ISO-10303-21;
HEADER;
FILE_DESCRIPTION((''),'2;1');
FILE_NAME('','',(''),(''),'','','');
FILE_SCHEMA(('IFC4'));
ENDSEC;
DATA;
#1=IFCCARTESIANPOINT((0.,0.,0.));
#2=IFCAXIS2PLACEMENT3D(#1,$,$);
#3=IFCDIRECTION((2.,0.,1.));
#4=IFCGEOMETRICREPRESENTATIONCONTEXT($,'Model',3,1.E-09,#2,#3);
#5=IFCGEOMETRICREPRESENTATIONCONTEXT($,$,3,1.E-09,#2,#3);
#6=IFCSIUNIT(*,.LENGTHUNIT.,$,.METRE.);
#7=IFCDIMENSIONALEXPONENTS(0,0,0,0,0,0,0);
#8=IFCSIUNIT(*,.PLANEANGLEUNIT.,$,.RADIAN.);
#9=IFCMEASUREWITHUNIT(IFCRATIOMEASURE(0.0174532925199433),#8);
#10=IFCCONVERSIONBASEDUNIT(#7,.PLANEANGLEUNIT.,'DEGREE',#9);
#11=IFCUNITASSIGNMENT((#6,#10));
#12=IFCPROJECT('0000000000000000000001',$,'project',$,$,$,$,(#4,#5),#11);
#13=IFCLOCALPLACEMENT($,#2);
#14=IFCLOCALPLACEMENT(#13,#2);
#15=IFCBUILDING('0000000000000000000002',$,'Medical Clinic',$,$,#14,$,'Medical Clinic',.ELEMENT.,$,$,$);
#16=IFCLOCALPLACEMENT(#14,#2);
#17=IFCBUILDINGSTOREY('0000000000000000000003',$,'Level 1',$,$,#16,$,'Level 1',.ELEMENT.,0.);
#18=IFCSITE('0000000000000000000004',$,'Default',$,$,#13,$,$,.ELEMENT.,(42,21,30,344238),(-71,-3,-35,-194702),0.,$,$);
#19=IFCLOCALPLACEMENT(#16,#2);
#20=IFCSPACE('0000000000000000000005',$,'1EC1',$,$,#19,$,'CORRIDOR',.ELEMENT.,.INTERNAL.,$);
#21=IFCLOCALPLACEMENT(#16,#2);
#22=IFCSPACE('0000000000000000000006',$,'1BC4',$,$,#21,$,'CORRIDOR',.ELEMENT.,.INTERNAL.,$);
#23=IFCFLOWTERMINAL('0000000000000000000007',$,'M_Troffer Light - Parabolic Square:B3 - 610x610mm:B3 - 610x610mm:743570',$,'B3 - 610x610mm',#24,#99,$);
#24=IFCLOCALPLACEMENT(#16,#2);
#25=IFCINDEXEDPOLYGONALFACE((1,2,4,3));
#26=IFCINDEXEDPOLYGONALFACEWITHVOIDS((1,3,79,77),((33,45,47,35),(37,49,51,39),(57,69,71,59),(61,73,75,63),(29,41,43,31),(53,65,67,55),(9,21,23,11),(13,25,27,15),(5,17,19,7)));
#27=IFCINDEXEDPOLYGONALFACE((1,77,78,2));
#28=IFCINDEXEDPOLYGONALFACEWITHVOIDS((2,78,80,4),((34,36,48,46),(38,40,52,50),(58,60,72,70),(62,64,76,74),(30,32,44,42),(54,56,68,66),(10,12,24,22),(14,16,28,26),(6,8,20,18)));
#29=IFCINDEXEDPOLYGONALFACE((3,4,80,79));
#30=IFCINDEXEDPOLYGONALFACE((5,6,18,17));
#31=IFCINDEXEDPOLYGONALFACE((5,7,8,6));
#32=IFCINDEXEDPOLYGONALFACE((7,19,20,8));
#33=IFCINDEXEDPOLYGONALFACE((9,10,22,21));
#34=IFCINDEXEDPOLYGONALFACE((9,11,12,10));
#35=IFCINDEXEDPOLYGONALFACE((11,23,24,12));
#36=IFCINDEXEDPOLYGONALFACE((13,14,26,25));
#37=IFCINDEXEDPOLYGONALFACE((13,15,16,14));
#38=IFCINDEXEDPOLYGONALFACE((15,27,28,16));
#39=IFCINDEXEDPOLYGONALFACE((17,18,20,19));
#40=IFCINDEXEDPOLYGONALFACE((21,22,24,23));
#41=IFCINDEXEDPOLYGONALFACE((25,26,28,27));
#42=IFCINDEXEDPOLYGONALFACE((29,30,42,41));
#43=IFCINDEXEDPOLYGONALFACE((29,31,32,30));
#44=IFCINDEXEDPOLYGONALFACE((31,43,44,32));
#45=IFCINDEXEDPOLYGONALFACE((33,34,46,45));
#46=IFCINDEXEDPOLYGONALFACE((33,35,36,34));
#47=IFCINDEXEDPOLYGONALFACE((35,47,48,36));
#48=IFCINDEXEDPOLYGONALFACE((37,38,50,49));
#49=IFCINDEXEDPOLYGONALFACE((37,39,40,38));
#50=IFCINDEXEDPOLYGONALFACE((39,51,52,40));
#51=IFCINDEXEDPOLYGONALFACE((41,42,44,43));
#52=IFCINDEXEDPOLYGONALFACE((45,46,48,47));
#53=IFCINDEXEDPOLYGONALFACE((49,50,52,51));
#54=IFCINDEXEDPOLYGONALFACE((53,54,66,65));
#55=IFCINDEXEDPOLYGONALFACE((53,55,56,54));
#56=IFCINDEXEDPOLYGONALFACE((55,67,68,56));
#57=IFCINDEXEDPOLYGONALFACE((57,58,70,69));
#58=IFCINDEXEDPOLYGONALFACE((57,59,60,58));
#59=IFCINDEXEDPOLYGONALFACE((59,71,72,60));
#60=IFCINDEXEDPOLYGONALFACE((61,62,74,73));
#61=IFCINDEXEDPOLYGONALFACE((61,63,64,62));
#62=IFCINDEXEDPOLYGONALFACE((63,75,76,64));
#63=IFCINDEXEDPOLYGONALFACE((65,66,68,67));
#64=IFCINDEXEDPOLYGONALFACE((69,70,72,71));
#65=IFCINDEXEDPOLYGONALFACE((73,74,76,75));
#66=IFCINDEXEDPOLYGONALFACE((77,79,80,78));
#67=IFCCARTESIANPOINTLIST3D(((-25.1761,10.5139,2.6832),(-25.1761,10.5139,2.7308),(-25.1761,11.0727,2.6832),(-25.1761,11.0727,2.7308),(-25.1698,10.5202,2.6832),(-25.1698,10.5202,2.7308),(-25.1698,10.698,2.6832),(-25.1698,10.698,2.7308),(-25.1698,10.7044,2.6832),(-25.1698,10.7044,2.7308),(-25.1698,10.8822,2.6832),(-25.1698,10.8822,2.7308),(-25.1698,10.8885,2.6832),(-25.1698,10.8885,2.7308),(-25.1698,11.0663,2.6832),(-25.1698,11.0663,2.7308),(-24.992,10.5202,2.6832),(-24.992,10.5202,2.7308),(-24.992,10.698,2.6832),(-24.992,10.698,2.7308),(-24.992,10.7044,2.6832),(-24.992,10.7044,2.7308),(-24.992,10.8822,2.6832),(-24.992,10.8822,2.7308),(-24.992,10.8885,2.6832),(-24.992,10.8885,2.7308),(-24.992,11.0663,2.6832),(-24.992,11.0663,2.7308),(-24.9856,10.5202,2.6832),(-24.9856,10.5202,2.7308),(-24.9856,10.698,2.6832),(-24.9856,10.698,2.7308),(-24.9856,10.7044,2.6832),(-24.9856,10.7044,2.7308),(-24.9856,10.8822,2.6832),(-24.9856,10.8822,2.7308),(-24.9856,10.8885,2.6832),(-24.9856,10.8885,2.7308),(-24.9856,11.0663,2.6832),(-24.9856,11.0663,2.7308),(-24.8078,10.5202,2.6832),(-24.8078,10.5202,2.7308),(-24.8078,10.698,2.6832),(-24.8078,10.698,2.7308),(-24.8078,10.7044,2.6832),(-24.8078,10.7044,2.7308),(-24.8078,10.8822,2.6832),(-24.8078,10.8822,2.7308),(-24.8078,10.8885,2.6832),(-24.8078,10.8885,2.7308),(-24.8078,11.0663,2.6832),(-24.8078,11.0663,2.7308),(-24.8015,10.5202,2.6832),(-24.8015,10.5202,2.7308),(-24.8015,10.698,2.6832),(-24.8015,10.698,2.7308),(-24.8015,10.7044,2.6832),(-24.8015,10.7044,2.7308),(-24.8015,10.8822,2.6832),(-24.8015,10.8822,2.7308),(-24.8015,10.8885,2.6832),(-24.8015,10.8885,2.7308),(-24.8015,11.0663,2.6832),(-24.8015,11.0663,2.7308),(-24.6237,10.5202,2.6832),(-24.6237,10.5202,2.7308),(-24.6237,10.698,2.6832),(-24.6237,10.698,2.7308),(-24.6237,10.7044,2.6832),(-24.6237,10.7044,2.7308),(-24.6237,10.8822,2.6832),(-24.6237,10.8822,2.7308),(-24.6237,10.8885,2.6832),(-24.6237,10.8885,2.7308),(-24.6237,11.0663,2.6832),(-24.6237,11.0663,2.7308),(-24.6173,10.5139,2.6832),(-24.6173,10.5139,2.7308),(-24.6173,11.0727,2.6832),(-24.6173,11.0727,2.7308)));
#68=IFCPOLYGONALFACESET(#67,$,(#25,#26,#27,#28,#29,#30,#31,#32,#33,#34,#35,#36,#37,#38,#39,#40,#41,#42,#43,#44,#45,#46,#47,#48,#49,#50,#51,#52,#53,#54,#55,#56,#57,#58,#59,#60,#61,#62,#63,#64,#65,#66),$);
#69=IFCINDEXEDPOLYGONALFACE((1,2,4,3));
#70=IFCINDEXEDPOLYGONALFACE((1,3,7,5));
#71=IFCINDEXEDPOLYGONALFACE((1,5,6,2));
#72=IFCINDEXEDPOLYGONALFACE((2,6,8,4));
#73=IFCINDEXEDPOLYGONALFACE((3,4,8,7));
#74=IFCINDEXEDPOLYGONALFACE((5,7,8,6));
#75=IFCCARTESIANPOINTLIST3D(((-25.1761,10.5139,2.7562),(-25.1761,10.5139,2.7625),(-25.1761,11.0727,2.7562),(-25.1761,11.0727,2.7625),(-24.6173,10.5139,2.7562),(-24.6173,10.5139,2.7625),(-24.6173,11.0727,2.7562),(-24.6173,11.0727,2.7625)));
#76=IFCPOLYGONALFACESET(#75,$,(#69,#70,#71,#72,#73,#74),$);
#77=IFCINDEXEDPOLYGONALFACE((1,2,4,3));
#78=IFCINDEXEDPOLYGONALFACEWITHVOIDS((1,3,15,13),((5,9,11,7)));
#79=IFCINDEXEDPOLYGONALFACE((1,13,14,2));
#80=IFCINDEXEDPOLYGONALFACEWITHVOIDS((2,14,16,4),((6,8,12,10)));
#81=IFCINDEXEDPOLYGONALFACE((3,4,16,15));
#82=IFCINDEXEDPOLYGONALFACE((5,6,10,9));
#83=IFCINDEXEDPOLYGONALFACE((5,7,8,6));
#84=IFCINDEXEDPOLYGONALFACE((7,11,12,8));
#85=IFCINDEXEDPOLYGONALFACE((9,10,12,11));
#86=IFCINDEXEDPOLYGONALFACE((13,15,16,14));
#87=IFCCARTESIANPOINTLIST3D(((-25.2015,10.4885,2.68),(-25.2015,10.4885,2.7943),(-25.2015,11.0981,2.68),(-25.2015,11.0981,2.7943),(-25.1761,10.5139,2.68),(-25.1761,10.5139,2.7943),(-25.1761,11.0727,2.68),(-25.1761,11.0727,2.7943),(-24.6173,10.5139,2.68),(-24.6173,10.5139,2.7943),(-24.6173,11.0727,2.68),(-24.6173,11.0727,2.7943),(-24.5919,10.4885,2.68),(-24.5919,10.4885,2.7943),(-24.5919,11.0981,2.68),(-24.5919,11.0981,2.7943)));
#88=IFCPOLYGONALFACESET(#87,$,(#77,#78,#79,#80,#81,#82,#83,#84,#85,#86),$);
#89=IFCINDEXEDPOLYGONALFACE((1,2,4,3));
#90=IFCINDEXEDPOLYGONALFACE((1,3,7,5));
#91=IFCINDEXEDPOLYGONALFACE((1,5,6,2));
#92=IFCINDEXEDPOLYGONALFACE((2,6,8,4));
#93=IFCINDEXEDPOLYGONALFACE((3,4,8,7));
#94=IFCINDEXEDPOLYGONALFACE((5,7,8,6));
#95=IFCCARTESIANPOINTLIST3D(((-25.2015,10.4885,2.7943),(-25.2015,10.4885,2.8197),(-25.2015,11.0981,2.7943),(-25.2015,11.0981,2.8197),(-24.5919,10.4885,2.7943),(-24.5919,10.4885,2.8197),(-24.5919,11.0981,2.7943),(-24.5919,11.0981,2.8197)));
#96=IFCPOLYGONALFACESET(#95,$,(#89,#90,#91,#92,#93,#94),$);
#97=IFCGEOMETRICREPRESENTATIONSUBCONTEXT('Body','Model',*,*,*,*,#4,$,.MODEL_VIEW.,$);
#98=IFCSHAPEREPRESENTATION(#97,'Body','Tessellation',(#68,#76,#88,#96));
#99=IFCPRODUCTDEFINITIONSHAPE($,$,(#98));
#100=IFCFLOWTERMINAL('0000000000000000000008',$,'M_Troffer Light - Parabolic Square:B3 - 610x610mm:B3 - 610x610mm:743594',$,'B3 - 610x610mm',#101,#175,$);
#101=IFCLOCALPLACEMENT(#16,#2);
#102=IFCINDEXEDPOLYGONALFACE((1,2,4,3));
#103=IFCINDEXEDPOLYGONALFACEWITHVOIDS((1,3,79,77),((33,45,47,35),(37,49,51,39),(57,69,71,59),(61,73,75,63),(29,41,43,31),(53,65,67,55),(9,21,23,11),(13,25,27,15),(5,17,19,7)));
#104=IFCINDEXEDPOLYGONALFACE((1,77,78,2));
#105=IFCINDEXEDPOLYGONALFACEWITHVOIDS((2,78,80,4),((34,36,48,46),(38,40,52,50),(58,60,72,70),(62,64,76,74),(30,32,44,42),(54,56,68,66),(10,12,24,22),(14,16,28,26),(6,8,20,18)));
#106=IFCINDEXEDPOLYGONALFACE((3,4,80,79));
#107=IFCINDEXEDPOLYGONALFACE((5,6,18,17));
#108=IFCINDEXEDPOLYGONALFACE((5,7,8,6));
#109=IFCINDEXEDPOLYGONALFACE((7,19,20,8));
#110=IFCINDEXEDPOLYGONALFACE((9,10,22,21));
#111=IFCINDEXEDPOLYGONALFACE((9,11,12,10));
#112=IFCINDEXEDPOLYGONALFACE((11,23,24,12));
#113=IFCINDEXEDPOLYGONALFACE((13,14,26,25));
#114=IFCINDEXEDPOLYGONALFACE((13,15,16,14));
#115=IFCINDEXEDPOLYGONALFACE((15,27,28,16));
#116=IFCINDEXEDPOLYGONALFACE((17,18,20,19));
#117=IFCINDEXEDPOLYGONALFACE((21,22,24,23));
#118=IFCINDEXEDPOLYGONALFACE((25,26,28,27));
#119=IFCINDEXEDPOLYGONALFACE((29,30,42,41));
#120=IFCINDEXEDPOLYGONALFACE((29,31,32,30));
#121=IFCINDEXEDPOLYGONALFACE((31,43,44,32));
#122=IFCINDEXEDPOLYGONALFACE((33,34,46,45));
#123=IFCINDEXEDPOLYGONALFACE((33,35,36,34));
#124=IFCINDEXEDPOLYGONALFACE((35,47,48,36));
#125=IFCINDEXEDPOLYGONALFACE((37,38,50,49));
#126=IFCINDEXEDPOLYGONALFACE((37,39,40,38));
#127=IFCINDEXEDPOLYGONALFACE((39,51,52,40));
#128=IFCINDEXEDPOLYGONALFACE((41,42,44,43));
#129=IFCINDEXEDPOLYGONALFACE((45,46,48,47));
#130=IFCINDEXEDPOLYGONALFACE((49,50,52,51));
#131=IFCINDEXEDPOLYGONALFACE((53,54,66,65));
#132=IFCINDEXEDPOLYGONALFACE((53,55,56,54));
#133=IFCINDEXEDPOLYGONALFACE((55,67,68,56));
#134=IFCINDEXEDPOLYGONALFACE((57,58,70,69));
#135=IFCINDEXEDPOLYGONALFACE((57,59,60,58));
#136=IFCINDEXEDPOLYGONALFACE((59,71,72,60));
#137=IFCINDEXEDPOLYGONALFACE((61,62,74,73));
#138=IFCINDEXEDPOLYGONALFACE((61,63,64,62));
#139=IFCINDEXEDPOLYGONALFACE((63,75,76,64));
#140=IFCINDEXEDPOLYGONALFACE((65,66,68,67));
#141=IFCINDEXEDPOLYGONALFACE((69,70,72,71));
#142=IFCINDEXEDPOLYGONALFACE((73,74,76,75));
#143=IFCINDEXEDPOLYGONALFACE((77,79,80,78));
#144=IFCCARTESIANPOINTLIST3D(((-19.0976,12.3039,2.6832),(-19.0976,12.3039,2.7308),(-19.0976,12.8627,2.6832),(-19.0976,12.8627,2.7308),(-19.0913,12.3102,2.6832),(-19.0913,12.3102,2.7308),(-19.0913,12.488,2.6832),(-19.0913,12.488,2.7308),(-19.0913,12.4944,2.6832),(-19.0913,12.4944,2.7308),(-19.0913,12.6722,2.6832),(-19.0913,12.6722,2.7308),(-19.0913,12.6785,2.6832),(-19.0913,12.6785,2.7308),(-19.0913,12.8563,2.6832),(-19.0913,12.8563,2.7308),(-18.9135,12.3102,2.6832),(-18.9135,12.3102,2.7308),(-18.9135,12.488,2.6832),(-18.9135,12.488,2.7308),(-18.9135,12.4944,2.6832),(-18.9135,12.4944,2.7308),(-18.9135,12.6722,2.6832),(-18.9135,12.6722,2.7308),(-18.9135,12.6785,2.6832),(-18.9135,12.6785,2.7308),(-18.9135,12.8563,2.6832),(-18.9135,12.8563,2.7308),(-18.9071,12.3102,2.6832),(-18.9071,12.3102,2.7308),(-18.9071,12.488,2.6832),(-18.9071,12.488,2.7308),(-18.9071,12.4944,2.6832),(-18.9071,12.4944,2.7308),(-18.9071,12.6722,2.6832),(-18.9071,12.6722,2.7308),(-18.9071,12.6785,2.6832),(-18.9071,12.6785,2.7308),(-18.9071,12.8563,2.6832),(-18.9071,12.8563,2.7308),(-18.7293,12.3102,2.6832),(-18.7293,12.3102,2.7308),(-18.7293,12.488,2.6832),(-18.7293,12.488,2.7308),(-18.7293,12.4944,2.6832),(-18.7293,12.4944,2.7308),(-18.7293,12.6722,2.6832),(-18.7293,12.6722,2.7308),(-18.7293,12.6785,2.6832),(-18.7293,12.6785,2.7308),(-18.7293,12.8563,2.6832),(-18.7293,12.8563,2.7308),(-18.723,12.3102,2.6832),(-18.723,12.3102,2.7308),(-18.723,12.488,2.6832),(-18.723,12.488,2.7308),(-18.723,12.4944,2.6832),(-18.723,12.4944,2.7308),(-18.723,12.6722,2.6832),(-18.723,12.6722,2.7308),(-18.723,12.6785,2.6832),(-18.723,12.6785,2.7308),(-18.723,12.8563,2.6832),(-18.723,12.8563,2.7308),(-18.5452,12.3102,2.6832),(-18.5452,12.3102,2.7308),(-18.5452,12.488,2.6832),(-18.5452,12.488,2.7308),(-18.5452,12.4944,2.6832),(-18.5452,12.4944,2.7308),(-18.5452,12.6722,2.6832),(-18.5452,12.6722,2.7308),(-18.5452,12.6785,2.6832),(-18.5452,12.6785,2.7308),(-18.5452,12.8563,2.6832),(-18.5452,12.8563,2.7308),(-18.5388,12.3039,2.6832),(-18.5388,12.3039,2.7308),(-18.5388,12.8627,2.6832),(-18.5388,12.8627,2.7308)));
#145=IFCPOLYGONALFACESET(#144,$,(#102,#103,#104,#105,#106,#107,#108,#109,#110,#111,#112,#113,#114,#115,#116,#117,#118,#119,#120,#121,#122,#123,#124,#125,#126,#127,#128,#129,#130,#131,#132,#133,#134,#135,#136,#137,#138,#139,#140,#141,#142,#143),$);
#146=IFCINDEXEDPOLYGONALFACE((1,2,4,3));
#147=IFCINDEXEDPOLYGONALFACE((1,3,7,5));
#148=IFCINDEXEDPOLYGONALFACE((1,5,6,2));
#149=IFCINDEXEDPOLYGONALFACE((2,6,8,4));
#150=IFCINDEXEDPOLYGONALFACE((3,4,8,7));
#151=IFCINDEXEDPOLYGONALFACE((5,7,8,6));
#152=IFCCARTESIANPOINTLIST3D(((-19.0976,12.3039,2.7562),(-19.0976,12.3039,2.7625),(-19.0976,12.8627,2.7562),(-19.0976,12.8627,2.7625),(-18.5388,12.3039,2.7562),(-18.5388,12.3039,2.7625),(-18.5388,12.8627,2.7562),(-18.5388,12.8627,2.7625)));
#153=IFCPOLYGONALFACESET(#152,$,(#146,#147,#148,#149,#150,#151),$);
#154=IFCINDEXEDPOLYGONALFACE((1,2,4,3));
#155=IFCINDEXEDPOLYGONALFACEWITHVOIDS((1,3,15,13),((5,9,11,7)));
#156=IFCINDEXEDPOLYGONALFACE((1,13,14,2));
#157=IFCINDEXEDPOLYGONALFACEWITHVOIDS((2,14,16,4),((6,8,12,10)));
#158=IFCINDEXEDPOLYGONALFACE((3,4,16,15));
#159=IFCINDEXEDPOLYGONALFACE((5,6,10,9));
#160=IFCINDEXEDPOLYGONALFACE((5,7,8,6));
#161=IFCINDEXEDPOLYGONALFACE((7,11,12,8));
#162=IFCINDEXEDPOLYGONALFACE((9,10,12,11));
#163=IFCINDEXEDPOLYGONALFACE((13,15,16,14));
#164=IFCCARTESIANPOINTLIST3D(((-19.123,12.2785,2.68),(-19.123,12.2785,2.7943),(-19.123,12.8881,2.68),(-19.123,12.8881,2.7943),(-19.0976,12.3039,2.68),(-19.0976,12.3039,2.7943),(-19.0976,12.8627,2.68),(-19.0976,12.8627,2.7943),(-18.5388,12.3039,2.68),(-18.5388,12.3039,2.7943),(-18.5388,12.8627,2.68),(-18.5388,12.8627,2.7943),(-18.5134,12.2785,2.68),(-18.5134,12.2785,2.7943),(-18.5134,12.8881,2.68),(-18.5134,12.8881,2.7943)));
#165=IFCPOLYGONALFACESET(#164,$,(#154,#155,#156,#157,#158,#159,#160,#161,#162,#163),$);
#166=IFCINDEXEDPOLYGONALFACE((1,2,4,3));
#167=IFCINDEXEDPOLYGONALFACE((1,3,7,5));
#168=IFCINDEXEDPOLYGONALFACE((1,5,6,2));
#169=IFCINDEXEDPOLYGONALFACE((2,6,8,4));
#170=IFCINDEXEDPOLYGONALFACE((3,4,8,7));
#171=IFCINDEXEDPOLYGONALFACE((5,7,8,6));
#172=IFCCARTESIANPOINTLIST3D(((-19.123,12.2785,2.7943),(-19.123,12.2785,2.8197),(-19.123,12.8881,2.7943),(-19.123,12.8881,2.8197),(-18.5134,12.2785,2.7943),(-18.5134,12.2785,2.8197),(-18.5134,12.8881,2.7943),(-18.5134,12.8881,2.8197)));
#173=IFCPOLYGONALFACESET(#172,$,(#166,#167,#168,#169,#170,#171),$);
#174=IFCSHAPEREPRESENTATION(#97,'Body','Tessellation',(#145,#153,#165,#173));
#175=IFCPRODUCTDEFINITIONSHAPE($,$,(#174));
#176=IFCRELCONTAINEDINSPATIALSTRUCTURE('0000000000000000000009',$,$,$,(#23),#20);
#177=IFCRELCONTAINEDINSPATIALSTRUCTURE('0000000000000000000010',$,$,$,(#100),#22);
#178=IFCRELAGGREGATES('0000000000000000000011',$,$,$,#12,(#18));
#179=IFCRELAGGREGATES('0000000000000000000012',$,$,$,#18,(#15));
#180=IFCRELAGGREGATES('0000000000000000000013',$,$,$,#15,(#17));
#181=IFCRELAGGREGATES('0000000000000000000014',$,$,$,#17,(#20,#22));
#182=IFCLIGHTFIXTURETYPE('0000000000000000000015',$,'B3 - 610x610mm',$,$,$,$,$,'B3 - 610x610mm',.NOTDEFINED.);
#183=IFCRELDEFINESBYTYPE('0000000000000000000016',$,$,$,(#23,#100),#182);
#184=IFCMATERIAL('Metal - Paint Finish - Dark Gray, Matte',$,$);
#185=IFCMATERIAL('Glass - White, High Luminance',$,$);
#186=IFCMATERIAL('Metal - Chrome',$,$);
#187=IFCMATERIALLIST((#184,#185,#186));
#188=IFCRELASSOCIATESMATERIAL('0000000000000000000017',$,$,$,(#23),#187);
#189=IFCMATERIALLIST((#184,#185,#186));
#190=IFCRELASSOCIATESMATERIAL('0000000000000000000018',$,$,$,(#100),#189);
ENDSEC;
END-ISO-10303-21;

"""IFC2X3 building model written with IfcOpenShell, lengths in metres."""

from ifc_helpers import new_model, entity, si_unit, converted_unit, direction, frame, origin, origin_2d_with_axis, place, context, subcontext, project, spatial, polyline, rectangle, outline, extrude, source, transform, mapped, material, material_list, type_object, type_shapes, element, save


model = new_model("IFC2X3")

# Units and contexts
model_context = context("Model", 3, precision=1e-09, world=origin(), true_north=direction((2.0, 0.0, 1.0)))
context_of_model = context(None, 3, precision=1e-09, world=origin(), true_north=direction((2.0, 0.0, 1.0)))
body_context = subcontext(model_context, "Body", "Model", "MODEL_VIEW")
ifc_project = project(units=[si_unit("LENGTHUNIT", "METRE"), converted_unit("PLANEANGLEUNIT", "DEGREE", entity("IfcRatioMeasure", 0.0174532925199433), si_unit("PLANEANGLEUNIT", "RADIAN"), dimensions=[0, 0, 0, 0, 0, 0, 0])], contexts=[model_context, context_of_model])

# Site, building, storey, space
site_placement = place(None, origin())
site = spatial("IfcSite", under=ifc_project, at=site_placement, Name="Default", CompositionType="ELEMENT", RefLatitude=(42, 21, 30, 344238), RefLongitude=(-71, -3, -35, -194702), RefElevation=0.0)
building_placement = place(site_placement, origin())
building = spatial("IfcBuilding", under=site, at=building_placement, Name="Medical Clinic", LongName="Medical Clinic", CompositionType="ELEMENT")
storey_placement = place(building_placement, origin())
storey = spatial("IfcBuildingStorey", under=building, at=storey_placement, Name="Level 1", LongName="Level 1", CompositionType="ELEMENT", Elevation=0.0)
space_1_placement = place(storey_placement, origin())
space_1 = spatial("IfcSpace", under=storey, at=space_1_placement, Name="1EC1", LongName="CORRIDOR", CompositionType="ELEMENT", InteriorOrExteriorSpace="INTERNAL")

# Flow terminal
ifc_material_1 = material(Name="Metal - Paint Finish - Dark Gray, Matte")
ifc_material_2 = material(Name="Glass - White, High Luminance")
ifc_material_3 = material(Name="Metal - Chrome")
ifc_material_list_1 = material_list([ifc_material_1, ifc_material_2, ifc_material_3])
light_fixture_type_1 = type_object("IfcLightFixtureType", Name="B3 - 610x610mm", ElementType="B3 - 610x610mm", PredefinedType="NOTDEFINED")
shared_shape_1 = source(origin(), body_context, "Body", "SweptSolid", [
    extrude(outline(polyline([(-0.2794, -0.2794), (0.2794, -0.2794), (0.2794, 0.2794), (-0.2794, 0.2794), (-0.2794, -0.2794)]), holes=[polyline([(-0.0952, 0.0953), (-0.273, 0.0953), (-0.273, 0.2731), (-0.0952, 0.2731), (-0.0952, 0.0953)]), polyline([(0.2731, 0.0953), (0.0953, 0.0953), (0.0953, 0.2731), (0.2731, 0.2731), (0.2731, 0.0953)]), polyline([(-0.0889, 0.2731), (0.0889, 0.2731), (0.0889, 0.0953), (-0.0889, 0.0953), (-0.0889, 0.2731)]), polyline([(0.2731, -0.273), (0.0953, -0.273), (0.0953, -0.0952), (0.2731, -0.0952), (0.2731, -0.273)]), polyline([(0.0889, -0.273), (-0.0889, -0.273), (-0.0889, -0.0952), (0.0889, -0.0952), (0.0889, -0.273)]), polyline([(-0.0952, -0.273), (-0.273, -0.273), (-0.273, -0.0952), (-0.0952, -0.0952), (-0.0952, -0.273)]), polyline([(-0.0952, -0.0889), (-0.273, -0.0889), (-0.273, 0.0889), (-0.0952, 0.0889), (-0.0952, -0.0889)]), polyline([(0.0889, -0.0889), (-0.0889, -0.0889), (-0.0889, 0.0889), (0.0889, 0.0889), (0.0889, -0.0889)]), polyline([(0.2731, -0.0889), (0.0953, -0.0889), (0.0953, 0.0889), (0.2731, 0.0889), (0.2731, -0.0889)])]), frame((0.0, -0.3048, -0.0508), z_axis=(0.0, 0.0, 1.0), x_axis=(-1.0, 0.0, 0.0)), (0.0, 0.0, 1.0), 0.0476),
    extrude(rectangle(XDim=0.5588, YDim=0.5588, at=origin_2d_with_axis()), frame((0.0, -0.3048, -0.0825), z_axis=(0.0, 0.0, 1.0), x_axis=(-1.0, 0.0, 0.0)), (0.0, 0.0, 1.0), 0.0064),
    extrude(outline(polyline([(-0.3048, -0.3048), (0.3048, -0.3048), (0.3048, 0.3048), (-0.3048, 0.3048), (-0.3048, -0.3048)]), holes=[polyline([(0.2794, 0.2794), (0.2794, -0.2794), (-0.2794, -0.2794), (-0.2794, 0.2794), (0.2794, 0.2794)])]), frame((0.0, -0.3048, -0.1143)), (0.0, 0.0, 1.0), 0.1143),
    extrude(rectangle(XDim=0.6096, YDim=0.6096, at=origin_2d_with_axis()), frame((0.0, -0.3048, -0.1397), z_axis=(0.0, 0.0, 1.0), x_axis=(-1.0, 0.0, 0.0)), (0.0, 0.0, 1.0), 0.0254),
])
type_shapes(light_fixture_type_1, [shared_shape_1])
flow_terminal_1_placement = place(space_1_placement, frame((-24.8967, 10.4885, 2.68), z_axis=(0.0, 0.0, -1.0), x_axis=(1.0, 0.0, 0.0)))
element("IfcFlowTerminal", 1, at=flow_terminal_1_placement, inside=space_1, type_object=light_fixture_type_1, material=ifc_material_list_1, Name="M_Troffer Light - Parabolic Square:B3 - 610x610mm:B3 - 610x610mm:743570", ObjectType="B3 - 610x610mm", context=body_context, shape_type="MappedRepresentation", body=[
    mapped(shared_shape_1, transform((0.0, 0.0, 0.0), scale=1.0)),
])

# Shared definitions
space_2_placement = place(storey_placement, origin())
space_2 = spatial("IfcSpace", under=storey, at=space_2_placement, Name="1BC4", LongName="CORRIDOR", CompositionType="ELEMENT", InteriorOrExteriorSpace="INTERNAL")

# Flow terminal
ifc_material_list_2 = material_list([ifc_material_1, ifc_material_2, ifc_material_3])
flow_terminal_2_placement = place(space_2_placement, frame((-18.8182, 12.2785, 2.68), z_axis=(0.0, 0.0, -1.0), x_axis=(1.0, 0.0, 0.0)))
element("IfcFlowTerminal", 2, at=flow_terminal_2_placement, inside=space_2, type_object=light_fixture_type_1, material=ifc_material_list_2, Name="M_Troffer Light - Parabolic Square:B3 - 610x610mm:B3 - 610x610mm:743594", ObjectType="B3 - 610x610mm", context=body_context, shape_type="MappedRepresentation", body=[
    mapped(shared_shape_1, transform((0.0, 0.0, 0.0), scale=1.0)),
])

save(model, "model.ifc")
